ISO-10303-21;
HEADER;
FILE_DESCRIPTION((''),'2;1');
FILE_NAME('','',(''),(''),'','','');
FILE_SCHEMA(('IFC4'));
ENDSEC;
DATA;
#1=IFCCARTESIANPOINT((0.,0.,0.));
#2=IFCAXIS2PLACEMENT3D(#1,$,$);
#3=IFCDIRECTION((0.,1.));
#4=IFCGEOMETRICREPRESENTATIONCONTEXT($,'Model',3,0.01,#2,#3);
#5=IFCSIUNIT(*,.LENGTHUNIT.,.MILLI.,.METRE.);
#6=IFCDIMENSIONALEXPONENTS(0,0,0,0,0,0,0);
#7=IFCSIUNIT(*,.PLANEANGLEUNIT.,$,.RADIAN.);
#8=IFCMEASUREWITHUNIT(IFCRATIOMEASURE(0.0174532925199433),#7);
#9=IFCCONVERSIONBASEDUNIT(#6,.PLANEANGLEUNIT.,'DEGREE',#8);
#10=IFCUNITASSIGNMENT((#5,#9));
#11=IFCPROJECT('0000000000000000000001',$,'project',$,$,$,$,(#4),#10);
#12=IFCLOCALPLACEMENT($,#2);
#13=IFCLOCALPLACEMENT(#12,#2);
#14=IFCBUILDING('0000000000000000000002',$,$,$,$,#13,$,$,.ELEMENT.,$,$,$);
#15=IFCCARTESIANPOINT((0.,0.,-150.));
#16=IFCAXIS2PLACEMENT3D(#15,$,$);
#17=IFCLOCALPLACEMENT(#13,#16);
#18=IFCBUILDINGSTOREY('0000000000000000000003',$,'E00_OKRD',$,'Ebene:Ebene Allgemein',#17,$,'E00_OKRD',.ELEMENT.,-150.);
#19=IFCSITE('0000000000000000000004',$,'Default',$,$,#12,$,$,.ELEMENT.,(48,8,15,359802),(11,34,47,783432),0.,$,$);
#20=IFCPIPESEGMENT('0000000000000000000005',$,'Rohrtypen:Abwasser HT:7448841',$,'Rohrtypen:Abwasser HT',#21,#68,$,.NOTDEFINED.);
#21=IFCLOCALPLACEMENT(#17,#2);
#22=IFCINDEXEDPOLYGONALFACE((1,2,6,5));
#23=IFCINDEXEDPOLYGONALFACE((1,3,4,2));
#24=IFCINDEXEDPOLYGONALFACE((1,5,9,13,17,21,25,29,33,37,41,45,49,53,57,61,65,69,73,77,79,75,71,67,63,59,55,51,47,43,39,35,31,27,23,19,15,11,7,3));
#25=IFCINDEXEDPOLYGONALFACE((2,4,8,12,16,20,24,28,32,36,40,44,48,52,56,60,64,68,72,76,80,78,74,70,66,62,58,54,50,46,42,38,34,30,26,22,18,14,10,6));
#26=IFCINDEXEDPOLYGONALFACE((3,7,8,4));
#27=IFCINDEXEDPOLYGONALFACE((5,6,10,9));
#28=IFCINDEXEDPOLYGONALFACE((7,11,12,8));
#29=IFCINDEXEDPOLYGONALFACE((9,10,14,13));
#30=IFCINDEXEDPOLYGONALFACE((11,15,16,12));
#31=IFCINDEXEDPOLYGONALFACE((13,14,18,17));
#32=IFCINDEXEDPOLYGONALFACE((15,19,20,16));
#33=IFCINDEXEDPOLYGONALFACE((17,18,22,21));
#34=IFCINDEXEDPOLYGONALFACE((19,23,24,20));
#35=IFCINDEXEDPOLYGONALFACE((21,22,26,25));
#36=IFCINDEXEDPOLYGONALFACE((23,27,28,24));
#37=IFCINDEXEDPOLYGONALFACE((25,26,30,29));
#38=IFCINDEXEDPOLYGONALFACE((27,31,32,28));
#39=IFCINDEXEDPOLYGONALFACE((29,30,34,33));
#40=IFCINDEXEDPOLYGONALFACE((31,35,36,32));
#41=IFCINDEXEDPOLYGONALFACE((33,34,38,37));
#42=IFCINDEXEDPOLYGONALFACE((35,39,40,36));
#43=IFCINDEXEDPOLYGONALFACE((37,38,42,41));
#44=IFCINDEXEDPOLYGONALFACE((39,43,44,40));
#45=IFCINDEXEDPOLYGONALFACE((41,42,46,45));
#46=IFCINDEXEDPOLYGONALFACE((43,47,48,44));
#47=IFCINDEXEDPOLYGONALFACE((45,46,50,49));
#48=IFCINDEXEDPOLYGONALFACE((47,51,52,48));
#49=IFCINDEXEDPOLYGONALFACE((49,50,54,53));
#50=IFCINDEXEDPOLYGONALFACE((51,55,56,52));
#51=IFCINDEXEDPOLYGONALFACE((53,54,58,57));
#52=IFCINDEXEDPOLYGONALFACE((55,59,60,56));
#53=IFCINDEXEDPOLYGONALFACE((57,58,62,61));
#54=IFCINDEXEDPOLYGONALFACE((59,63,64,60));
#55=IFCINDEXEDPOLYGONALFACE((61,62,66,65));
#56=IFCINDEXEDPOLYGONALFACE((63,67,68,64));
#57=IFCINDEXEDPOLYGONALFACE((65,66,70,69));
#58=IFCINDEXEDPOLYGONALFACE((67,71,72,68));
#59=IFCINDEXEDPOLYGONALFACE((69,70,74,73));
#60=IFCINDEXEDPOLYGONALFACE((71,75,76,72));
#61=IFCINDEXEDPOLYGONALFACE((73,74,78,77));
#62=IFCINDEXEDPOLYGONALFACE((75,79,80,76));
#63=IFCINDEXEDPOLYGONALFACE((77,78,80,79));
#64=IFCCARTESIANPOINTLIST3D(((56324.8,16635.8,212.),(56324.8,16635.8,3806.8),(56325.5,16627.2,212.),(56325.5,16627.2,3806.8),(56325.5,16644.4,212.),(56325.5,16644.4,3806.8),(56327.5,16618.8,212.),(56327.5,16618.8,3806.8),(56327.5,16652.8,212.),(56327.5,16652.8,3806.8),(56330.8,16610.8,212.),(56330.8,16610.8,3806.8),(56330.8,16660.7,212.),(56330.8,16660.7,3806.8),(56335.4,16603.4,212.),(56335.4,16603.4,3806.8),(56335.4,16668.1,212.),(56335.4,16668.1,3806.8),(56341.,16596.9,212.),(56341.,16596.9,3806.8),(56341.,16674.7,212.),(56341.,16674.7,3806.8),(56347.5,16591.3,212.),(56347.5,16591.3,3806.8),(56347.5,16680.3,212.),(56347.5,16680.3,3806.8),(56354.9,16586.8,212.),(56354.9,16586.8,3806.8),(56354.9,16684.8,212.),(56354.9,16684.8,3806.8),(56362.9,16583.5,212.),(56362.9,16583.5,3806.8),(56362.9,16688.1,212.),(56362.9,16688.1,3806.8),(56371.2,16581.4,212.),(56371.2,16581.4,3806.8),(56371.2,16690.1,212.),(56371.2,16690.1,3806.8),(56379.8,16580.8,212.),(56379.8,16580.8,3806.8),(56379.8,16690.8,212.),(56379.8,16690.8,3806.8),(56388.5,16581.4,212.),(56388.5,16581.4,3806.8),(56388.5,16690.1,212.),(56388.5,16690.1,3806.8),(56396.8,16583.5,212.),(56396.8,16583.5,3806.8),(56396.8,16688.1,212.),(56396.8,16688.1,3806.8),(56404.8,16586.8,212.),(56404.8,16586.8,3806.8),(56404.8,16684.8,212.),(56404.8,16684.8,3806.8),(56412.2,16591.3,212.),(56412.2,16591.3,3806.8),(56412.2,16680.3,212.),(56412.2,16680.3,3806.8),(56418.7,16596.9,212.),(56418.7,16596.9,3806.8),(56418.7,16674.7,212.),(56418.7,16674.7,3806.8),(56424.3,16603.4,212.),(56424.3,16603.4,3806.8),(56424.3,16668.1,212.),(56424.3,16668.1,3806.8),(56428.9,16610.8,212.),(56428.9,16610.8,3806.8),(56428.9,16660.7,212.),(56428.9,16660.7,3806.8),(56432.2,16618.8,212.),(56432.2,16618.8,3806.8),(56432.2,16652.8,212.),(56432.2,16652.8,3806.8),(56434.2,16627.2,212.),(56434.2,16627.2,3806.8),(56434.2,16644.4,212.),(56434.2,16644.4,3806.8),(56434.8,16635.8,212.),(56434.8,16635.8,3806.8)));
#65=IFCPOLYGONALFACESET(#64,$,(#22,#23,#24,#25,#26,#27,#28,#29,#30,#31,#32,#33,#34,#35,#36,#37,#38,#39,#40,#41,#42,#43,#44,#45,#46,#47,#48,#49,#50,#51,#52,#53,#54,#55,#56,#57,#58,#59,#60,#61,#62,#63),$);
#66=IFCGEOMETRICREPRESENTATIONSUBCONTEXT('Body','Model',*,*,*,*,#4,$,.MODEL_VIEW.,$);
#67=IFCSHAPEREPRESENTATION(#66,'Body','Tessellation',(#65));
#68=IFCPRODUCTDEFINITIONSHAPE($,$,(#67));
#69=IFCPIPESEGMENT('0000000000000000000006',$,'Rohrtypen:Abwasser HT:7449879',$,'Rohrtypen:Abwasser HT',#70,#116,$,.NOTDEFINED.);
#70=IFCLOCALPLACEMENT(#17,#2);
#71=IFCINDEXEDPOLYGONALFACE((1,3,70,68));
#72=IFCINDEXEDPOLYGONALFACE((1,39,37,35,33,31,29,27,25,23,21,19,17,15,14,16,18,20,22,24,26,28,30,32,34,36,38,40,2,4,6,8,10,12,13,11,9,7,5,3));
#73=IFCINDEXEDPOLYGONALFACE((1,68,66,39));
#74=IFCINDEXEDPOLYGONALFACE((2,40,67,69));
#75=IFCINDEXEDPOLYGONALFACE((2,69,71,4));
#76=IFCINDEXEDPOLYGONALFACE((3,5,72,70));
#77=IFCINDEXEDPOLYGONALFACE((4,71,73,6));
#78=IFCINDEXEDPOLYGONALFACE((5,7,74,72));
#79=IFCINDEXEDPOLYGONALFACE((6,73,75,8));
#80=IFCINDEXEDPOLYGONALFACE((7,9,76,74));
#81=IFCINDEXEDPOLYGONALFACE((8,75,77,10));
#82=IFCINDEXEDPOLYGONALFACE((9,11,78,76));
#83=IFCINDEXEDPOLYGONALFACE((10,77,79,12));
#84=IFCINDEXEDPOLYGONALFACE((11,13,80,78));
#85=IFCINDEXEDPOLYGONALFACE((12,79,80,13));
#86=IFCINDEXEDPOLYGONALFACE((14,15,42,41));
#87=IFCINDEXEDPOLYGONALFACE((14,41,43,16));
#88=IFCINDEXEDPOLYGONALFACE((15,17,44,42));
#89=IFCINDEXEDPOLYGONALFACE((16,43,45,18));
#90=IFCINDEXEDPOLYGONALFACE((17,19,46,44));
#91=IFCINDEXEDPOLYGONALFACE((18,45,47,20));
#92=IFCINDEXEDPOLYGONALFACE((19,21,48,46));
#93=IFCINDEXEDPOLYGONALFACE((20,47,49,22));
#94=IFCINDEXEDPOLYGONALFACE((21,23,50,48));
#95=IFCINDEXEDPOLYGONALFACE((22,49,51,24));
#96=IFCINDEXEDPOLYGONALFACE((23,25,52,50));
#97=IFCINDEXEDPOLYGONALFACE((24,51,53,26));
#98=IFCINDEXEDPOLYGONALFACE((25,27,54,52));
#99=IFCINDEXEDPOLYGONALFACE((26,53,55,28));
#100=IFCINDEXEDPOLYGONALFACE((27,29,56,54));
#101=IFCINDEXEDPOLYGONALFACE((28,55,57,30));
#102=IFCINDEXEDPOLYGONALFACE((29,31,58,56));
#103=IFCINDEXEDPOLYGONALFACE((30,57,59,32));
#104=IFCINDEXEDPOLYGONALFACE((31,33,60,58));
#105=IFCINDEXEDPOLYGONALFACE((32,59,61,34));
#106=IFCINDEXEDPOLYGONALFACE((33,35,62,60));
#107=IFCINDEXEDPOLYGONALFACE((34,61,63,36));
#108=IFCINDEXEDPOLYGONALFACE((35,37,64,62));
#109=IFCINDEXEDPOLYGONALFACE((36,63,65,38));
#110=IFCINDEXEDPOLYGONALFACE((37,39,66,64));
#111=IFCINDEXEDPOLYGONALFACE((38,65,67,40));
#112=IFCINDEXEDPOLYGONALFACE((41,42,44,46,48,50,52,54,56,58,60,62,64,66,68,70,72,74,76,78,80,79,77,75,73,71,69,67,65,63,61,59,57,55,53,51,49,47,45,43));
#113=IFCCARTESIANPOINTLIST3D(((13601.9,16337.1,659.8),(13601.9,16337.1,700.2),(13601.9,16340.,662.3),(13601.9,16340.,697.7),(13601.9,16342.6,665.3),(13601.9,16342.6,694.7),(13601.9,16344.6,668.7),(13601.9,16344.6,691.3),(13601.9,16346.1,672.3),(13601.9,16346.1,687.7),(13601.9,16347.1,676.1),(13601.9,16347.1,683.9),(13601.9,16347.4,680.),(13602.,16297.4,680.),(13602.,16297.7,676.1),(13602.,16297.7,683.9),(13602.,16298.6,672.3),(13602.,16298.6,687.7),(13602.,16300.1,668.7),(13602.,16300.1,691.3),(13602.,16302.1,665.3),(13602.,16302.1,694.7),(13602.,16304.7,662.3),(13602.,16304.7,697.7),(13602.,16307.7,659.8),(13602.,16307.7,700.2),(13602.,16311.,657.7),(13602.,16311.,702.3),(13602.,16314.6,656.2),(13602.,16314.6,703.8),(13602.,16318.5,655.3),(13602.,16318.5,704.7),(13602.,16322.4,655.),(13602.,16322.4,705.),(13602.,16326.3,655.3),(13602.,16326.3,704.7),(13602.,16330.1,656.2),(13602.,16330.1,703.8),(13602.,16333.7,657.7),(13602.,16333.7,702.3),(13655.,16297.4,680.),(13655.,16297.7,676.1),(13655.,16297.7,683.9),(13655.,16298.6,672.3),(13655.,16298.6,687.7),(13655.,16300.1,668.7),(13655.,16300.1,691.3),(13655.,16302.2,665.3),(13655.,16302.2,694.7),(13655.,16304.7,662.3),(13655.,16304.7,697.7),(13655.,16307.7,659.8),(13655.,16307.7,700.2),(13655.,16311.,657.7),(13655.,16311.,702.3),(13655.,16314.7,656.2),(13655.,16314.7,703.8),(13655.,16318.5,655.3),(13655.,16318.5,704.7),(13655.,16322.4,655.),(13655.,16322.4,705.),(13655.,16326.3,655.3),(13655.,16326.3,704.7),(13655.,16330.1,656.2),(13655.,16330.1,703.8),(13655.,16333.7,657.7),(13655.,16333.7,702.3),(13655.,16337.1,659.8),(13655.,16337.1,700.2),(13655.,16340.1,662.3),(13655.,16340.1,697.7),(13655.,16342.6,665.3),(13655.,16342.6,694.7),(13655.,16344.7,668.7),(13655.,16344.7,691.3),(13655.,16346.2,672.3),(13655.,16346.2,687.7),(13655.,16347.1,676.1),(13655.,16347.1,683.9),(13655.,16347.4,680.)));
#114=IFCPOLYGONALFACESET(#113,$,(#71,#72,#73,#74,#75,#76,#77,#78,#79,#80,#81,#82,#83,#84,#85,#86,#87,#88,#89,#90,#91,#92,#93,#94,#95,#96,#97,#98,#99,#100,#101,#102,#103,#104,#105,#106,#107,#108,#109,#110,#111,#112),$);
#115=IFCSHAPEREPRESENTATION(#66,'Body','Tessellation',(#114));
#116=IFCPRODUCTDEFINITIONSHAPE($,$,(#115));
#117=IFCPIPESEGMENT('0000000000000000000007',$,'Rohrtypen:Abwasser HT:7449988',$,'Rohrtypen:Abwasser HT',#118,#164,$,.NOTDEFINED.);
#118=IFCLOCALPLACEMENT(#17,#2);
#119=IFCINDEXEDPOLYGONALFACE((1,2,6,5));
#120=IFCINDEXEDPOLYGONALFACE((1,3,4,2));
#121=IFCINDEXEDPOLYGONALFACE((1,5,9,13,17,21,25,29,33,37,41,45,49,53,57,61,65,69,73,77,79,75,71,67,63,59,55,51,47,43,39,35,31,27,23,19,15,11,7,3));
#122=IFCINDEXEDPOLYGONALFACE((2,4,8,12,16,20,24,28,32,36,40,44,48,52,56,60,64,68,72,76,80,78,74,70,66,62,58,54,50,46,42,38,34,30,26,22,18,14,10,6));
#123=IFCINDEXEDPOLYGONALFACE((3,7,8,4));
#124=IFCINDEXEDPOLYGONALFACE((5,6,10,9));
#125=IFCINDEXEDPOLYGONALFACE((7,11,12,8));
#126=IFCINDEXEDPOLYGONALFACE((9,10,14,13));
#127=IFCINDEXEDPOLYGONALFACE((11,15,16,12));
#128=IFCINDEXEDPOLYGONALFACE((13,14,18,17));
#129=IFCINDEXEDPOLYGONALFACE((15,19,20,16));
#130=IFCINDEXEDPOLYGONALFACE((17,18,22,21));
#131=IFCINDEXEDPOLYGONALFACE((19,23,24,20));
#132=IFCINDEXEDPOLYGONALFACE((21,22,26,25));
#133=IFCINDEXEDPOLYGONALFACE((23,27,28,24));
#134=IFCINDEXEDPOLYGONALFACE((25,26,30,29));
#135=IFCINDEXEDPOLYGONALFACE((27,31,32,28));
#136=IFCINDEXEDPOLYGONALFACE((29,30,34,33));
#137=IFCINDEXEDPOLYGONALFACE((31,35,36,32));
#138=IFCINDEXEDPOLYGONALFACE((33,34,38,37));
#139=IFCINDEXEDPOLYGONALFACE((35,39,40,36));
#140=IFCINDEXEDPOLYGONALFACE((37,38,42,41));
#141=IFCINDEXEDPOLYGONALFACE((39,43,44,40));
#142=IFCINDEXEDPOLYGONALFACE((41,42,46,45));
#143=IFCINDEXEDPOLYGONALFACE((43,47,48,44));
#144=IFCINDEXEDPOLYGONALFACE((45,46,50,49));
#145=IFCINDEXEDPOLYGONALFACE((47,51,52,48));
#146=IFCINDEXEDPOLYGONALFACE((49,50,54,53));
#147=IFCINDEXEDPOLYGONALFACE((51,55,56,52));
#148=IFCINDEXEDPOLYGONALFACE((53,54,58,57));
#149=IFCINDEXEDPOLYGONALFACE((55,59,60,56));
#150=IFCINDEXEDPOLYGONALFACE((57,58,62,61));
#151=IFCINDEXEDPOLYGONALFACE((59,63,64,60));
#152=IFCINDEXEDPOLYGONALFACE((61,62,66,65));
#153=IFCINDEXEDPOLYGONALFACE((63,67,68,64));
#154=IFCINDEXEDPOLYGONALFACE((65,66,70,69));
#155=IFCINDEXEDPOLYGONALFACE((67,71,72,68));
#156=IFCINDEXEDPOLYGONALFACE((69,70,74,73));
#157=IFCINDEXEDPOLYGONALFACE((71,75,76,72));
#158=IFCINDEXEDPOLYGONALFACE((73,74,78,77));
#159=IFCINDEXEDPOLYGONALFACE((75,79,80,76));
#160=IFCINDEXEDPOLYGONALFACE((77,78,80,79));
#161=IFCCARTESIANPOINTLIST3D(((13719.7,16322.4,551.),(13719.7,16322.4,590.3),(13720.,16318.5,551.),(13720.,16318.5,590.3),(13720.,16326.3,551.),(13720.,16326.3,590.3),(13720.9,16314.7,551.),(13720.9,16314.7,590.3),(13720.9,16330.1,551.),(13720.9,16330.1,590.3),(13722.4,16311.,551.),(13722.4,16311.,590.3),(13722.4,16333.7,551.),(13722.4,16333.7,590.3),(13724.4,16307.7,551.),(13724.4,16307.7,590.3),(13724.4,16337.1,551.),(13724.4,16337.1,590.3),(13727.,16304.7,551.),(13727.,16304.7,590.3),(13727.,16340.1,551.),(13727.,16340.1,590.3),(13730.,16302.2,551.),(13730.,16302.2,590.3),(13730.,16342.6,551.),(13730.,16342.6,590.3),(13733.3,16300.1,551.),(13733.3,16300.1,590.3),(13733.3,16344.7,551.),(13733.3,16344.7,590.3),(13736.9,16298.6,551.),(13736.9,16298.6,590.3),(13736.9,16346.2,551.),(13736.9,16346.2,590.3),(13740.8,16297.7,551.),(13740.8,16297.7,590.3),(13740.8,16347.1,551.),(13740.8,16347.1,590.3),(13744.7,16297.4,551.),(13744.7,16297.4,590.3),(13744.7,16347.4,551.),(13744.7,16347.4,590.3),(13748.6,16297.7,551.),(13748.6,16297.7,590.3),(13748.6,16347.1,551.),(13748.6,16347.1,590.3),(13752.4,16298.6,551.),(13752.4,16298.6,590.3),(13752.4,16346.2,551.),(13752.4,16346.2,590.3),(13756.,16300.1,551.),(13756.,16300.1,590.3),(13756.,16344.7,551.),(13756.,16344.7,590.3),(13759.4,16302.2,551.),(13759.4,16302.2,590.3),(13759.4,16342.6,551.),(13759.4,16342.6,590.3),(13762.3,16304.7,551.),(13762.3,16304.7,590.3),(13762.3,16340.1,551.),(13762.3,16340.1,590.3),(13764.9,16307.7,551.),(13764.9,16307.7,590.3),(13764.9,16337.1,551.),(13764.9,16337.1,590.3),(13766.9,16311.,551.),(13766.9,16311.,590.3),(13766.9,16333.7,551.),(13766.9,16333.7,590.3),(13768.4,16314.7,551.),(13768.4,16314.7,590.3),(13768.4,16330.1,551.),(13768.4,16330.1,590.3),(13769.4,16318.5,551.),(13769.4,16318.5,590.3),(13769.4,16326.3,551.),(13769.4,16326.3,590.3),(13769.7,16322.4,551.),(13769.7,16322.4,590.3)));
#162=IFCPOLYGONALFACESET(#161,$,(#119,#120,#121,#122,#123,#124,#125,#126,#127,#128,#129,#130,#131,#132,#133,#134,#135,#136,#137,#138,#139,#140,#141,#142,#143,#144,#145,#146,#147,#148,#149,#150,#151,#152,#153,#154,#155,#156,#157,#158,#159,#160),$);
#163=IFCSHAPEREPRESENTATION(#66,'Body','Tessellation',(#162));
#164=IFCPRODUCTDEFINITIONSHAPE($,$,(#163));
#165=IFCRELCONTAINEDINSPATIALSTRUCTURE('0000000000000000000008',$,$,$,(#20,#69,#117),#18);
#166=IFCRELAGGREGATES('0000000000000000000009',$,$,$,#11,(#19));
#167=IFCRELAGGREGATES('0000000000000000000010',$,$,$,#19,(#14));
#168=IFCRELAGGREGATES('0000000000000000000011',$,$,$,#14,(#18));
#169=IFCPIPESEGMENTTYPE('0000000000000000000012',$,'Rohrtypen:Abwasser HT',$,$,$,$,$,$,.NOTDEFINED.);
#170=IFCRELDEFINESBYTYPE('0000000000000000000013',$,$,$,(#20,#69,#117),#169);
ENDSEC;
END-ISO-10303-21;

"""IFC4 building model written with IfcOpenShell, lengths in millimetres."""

from ifc_helpers import new_model, entity, si_unit, converted_unit, direction, frame, origin, place, context, subcontext, project, spatial, indexed_curve, outline, extrude, type_object, element, save


model = new_model("IFC4")

# Units and contexts
model_context = context("Model", 3, precision=0.01, world=origin(), true_north=direction((0.0, 1.0)))
body_context = subcontext(model_context, "Body", "Model", "MODEL_VIEW")
ifc_project = project(units=[si_unit("LENGTHUNIT", "METRE", prefix="MILLI"), converted_unit("PLANEANGLEUNIT", "DEGREE", entity("IfcRatioMeasure", 0.0174532925199433), si_unit("PLANEANGLEUNIT", "RADIAN"), dimensions=[0, 0, 0, 0, 0, 0, 0])], contexts=[model_context])

# Site, building, storey
site_placement = place(None, origin())
site = spatial("IfcSite", under=ifc_project, at=site_placement, Name="Default", CompositionType="ELEMENT", RefLatitude=(48, 8, 15, 359802), RefLongitude=(11, 34, 47, 783432), RefElevation=0.0)
building_placement = place(site_placement, origin())
building = spatial("IfcBuilding", under=site, at=building_placement, CompositionType="ELEMENT")
storey_placement = place(building_placement, frame((0.0, 0.0, -150.0)))
storey = spatial("IfcBuildingStorey", under=building, at=storey_placement, Name="E00_OKRD", ObjectType="Ebene:Ebene Allgemein", LongName="E00_OKRD", CompositionType="ELEMENT", Elevation=-150.0)

# Pipe segments
pipe_segment_type_1 = type_object("IfcPipeSegmentType", Name="Rohrtypen:Abwasser HT", PredefinedType="NOTDEFINED")
pipe_segment_1_placement = place(storey_placement, origin())
element("IfcPipeSegment", 1, at=pipe_segment_1_placement, inside=storey, type_object=pipe_segment_type_1, Name="Rohrtypen:Abwasser HT:7448841", ObjectType="Rohrtypen:Abwasser HT", PredefinedType="NOTDEFINED", context=body_context, shape_type="SweptSolid", body=[
    extrude(outline(indexed_curve([(55.0, 0.0), (54.3, 8.6), (52.3, 17.0), (49.0, 25.0), (44.5, 32.3), (38.9, 38.9), (32.3, 44.5), (25.0, 49.0), (17.0, 52.3), (8.6, 54.3), (0.0, 55.0), (-8.6, 54.3), (-17.0, 52.3), (-25.0, 49.0), (-32.3, 44.5), (-38.9, 38.9), (-44.5, 32.3), (-49.0, 25.0), (-52.3, 17.0), (-54.3, 8.6), (-55.0, 0.0), (-54.3, -8.6), (-52.3, -17.0), (-49.0, -25.0), (-44.5, -32.3), (-38.9, -38.9), (-32.3, -44.5), (-25.0, -49.0), (-17.0, -52.3), (-8.6, -54.3), (0.0, -55.0), (8.6, -54.3), (17.0, -52.3), (25.0, -49.0), (32.3, -44.5), (38.9, -38.9), (44.5, -32.3), (49.0, -25.0), (52.3, -17.0), (54.3, -8.6), (55.0, 0.0)], self_intersect=False)), frame((56379.8, 16635.8, 212.0), z_axis=(0.0, 0.0, 1.0), x_axis=(-1.0, 0.0, 0.0)), (0.0, 0.0, 1.0), 3594.9),
])
pipe_segment_2_placement = place(storey_placement, origin())
element("IfcPipeSegment", 2, at=pipe_segment_2_placement, inside=storey, type_object=pipe_segment_type_1, Name="Rohrtypen:Abwasser HT:7449879", ObjectType="Rohrtypen:Abwasser HT", PredefinedType="NOTDEFINED", context=body_context, shape_type="SweptSolid", body=[
    extrude(outline(indexed_curve([(25.0, 0.0), (24.7, 3.9), (23.8, 7.7), (22.3, 11.3), (20.2, 14.7), (17.7, 17.7), (14.7, 20.2), (11.3, 22.3), (7.7, 23.8), (3.9, 24.7), (0.0, 25.0), (-3.9, 24.7), (-7.7, 23.8), (-11.3, 22.3), (-14.7, 20.2), (-17.7, 17.7), (-20.2, 14.7), (-22.3, 11.3), (-23.8, 7.7), (-24.7, 3.9), (-25.0, 0.0), (-24.7, -3.9), (-23.8, -7.7), (-22.3, -11.3), (-20.2, -14.7), (-17.7, -17.7), (-14.7, -20.2), (-11.3, -22.3), (-7.7, -23.8), (-3.9, -24.7), (0.0, -25.0), (3.9, -24.7), (7.7, -23.8), (11.3, -22.3), (14.7, -20.2), (17.7, -17.7), (20.2, -14.7), (22.3, -11.3), (23.8, -7.7), (24.7, -3.9), (25.0, 0.0)], self_intersect=False)), frame((13602.0, 16322.4, 680.0), z_axis=(1.0, 0.000238, 0.0), x_axis=(0.000238, -1.0, 0.0)), (0.0, 0.0, 1.0), 53.1),
])
pipe_segment_3_placement = place(storey_placement, origin())
element("IfcPipeSegment", 3, at=pipe_segment_3_placement, inside=storey, type_object=pipe_segment_type_1, Name="Rohrtypen:Abwasser HT:7449988", ObjectType="Rohrtypen:Abwasser HT", PredefinedType="NOTDEFINED", context=body_context, shape_type="SweptSolid", body=[
    extrude(outline(indexed_curve([(25.0, 0.0), (24.7, 3.9), (23.8, 7.7), (22.3, 11.3), (20.2, 14.7), (17.7, 17.7), (14.7, 20.2), (11.3, 22.3), (7.7, 23.8), (3.9, 24.7), (0.0, 25.0), (-3.9, 24.7), (-7.7, 23.8), (-11.3, 22.3), (-14.7, 20.2), (-17.7, 17.7), (-20.2, 14.7), (-22.3, 11.3), (-23.8, 7.7), (-24.7, 3.9), (-25.0, 0.0), (-24.7, -3.9), (-23.8, -7.7), (-22.3, -11.3), (-20.2, -14.7), (-17.7, -17.7), (-14.7, -20.2), (-11.3, -22.3), (-7.7, -23.8), (-3.9, -24.7), (0.0, -25.0), (3.9, -24.7), (7.7, -23.8), (11.3, -22.3), (14.7, -20.2), (17.7, -17.7), (20.2, -14.7), (22.3, -11.3), (23.8, -7.7), (24.7, -3.9), (25.0, 0.0)], self_intersect=False)), frame((13744.7, 16322.4, 551.0)), (0.0, 0.0, 1.0), 39.4),
])

save(model, "model.ifc")
